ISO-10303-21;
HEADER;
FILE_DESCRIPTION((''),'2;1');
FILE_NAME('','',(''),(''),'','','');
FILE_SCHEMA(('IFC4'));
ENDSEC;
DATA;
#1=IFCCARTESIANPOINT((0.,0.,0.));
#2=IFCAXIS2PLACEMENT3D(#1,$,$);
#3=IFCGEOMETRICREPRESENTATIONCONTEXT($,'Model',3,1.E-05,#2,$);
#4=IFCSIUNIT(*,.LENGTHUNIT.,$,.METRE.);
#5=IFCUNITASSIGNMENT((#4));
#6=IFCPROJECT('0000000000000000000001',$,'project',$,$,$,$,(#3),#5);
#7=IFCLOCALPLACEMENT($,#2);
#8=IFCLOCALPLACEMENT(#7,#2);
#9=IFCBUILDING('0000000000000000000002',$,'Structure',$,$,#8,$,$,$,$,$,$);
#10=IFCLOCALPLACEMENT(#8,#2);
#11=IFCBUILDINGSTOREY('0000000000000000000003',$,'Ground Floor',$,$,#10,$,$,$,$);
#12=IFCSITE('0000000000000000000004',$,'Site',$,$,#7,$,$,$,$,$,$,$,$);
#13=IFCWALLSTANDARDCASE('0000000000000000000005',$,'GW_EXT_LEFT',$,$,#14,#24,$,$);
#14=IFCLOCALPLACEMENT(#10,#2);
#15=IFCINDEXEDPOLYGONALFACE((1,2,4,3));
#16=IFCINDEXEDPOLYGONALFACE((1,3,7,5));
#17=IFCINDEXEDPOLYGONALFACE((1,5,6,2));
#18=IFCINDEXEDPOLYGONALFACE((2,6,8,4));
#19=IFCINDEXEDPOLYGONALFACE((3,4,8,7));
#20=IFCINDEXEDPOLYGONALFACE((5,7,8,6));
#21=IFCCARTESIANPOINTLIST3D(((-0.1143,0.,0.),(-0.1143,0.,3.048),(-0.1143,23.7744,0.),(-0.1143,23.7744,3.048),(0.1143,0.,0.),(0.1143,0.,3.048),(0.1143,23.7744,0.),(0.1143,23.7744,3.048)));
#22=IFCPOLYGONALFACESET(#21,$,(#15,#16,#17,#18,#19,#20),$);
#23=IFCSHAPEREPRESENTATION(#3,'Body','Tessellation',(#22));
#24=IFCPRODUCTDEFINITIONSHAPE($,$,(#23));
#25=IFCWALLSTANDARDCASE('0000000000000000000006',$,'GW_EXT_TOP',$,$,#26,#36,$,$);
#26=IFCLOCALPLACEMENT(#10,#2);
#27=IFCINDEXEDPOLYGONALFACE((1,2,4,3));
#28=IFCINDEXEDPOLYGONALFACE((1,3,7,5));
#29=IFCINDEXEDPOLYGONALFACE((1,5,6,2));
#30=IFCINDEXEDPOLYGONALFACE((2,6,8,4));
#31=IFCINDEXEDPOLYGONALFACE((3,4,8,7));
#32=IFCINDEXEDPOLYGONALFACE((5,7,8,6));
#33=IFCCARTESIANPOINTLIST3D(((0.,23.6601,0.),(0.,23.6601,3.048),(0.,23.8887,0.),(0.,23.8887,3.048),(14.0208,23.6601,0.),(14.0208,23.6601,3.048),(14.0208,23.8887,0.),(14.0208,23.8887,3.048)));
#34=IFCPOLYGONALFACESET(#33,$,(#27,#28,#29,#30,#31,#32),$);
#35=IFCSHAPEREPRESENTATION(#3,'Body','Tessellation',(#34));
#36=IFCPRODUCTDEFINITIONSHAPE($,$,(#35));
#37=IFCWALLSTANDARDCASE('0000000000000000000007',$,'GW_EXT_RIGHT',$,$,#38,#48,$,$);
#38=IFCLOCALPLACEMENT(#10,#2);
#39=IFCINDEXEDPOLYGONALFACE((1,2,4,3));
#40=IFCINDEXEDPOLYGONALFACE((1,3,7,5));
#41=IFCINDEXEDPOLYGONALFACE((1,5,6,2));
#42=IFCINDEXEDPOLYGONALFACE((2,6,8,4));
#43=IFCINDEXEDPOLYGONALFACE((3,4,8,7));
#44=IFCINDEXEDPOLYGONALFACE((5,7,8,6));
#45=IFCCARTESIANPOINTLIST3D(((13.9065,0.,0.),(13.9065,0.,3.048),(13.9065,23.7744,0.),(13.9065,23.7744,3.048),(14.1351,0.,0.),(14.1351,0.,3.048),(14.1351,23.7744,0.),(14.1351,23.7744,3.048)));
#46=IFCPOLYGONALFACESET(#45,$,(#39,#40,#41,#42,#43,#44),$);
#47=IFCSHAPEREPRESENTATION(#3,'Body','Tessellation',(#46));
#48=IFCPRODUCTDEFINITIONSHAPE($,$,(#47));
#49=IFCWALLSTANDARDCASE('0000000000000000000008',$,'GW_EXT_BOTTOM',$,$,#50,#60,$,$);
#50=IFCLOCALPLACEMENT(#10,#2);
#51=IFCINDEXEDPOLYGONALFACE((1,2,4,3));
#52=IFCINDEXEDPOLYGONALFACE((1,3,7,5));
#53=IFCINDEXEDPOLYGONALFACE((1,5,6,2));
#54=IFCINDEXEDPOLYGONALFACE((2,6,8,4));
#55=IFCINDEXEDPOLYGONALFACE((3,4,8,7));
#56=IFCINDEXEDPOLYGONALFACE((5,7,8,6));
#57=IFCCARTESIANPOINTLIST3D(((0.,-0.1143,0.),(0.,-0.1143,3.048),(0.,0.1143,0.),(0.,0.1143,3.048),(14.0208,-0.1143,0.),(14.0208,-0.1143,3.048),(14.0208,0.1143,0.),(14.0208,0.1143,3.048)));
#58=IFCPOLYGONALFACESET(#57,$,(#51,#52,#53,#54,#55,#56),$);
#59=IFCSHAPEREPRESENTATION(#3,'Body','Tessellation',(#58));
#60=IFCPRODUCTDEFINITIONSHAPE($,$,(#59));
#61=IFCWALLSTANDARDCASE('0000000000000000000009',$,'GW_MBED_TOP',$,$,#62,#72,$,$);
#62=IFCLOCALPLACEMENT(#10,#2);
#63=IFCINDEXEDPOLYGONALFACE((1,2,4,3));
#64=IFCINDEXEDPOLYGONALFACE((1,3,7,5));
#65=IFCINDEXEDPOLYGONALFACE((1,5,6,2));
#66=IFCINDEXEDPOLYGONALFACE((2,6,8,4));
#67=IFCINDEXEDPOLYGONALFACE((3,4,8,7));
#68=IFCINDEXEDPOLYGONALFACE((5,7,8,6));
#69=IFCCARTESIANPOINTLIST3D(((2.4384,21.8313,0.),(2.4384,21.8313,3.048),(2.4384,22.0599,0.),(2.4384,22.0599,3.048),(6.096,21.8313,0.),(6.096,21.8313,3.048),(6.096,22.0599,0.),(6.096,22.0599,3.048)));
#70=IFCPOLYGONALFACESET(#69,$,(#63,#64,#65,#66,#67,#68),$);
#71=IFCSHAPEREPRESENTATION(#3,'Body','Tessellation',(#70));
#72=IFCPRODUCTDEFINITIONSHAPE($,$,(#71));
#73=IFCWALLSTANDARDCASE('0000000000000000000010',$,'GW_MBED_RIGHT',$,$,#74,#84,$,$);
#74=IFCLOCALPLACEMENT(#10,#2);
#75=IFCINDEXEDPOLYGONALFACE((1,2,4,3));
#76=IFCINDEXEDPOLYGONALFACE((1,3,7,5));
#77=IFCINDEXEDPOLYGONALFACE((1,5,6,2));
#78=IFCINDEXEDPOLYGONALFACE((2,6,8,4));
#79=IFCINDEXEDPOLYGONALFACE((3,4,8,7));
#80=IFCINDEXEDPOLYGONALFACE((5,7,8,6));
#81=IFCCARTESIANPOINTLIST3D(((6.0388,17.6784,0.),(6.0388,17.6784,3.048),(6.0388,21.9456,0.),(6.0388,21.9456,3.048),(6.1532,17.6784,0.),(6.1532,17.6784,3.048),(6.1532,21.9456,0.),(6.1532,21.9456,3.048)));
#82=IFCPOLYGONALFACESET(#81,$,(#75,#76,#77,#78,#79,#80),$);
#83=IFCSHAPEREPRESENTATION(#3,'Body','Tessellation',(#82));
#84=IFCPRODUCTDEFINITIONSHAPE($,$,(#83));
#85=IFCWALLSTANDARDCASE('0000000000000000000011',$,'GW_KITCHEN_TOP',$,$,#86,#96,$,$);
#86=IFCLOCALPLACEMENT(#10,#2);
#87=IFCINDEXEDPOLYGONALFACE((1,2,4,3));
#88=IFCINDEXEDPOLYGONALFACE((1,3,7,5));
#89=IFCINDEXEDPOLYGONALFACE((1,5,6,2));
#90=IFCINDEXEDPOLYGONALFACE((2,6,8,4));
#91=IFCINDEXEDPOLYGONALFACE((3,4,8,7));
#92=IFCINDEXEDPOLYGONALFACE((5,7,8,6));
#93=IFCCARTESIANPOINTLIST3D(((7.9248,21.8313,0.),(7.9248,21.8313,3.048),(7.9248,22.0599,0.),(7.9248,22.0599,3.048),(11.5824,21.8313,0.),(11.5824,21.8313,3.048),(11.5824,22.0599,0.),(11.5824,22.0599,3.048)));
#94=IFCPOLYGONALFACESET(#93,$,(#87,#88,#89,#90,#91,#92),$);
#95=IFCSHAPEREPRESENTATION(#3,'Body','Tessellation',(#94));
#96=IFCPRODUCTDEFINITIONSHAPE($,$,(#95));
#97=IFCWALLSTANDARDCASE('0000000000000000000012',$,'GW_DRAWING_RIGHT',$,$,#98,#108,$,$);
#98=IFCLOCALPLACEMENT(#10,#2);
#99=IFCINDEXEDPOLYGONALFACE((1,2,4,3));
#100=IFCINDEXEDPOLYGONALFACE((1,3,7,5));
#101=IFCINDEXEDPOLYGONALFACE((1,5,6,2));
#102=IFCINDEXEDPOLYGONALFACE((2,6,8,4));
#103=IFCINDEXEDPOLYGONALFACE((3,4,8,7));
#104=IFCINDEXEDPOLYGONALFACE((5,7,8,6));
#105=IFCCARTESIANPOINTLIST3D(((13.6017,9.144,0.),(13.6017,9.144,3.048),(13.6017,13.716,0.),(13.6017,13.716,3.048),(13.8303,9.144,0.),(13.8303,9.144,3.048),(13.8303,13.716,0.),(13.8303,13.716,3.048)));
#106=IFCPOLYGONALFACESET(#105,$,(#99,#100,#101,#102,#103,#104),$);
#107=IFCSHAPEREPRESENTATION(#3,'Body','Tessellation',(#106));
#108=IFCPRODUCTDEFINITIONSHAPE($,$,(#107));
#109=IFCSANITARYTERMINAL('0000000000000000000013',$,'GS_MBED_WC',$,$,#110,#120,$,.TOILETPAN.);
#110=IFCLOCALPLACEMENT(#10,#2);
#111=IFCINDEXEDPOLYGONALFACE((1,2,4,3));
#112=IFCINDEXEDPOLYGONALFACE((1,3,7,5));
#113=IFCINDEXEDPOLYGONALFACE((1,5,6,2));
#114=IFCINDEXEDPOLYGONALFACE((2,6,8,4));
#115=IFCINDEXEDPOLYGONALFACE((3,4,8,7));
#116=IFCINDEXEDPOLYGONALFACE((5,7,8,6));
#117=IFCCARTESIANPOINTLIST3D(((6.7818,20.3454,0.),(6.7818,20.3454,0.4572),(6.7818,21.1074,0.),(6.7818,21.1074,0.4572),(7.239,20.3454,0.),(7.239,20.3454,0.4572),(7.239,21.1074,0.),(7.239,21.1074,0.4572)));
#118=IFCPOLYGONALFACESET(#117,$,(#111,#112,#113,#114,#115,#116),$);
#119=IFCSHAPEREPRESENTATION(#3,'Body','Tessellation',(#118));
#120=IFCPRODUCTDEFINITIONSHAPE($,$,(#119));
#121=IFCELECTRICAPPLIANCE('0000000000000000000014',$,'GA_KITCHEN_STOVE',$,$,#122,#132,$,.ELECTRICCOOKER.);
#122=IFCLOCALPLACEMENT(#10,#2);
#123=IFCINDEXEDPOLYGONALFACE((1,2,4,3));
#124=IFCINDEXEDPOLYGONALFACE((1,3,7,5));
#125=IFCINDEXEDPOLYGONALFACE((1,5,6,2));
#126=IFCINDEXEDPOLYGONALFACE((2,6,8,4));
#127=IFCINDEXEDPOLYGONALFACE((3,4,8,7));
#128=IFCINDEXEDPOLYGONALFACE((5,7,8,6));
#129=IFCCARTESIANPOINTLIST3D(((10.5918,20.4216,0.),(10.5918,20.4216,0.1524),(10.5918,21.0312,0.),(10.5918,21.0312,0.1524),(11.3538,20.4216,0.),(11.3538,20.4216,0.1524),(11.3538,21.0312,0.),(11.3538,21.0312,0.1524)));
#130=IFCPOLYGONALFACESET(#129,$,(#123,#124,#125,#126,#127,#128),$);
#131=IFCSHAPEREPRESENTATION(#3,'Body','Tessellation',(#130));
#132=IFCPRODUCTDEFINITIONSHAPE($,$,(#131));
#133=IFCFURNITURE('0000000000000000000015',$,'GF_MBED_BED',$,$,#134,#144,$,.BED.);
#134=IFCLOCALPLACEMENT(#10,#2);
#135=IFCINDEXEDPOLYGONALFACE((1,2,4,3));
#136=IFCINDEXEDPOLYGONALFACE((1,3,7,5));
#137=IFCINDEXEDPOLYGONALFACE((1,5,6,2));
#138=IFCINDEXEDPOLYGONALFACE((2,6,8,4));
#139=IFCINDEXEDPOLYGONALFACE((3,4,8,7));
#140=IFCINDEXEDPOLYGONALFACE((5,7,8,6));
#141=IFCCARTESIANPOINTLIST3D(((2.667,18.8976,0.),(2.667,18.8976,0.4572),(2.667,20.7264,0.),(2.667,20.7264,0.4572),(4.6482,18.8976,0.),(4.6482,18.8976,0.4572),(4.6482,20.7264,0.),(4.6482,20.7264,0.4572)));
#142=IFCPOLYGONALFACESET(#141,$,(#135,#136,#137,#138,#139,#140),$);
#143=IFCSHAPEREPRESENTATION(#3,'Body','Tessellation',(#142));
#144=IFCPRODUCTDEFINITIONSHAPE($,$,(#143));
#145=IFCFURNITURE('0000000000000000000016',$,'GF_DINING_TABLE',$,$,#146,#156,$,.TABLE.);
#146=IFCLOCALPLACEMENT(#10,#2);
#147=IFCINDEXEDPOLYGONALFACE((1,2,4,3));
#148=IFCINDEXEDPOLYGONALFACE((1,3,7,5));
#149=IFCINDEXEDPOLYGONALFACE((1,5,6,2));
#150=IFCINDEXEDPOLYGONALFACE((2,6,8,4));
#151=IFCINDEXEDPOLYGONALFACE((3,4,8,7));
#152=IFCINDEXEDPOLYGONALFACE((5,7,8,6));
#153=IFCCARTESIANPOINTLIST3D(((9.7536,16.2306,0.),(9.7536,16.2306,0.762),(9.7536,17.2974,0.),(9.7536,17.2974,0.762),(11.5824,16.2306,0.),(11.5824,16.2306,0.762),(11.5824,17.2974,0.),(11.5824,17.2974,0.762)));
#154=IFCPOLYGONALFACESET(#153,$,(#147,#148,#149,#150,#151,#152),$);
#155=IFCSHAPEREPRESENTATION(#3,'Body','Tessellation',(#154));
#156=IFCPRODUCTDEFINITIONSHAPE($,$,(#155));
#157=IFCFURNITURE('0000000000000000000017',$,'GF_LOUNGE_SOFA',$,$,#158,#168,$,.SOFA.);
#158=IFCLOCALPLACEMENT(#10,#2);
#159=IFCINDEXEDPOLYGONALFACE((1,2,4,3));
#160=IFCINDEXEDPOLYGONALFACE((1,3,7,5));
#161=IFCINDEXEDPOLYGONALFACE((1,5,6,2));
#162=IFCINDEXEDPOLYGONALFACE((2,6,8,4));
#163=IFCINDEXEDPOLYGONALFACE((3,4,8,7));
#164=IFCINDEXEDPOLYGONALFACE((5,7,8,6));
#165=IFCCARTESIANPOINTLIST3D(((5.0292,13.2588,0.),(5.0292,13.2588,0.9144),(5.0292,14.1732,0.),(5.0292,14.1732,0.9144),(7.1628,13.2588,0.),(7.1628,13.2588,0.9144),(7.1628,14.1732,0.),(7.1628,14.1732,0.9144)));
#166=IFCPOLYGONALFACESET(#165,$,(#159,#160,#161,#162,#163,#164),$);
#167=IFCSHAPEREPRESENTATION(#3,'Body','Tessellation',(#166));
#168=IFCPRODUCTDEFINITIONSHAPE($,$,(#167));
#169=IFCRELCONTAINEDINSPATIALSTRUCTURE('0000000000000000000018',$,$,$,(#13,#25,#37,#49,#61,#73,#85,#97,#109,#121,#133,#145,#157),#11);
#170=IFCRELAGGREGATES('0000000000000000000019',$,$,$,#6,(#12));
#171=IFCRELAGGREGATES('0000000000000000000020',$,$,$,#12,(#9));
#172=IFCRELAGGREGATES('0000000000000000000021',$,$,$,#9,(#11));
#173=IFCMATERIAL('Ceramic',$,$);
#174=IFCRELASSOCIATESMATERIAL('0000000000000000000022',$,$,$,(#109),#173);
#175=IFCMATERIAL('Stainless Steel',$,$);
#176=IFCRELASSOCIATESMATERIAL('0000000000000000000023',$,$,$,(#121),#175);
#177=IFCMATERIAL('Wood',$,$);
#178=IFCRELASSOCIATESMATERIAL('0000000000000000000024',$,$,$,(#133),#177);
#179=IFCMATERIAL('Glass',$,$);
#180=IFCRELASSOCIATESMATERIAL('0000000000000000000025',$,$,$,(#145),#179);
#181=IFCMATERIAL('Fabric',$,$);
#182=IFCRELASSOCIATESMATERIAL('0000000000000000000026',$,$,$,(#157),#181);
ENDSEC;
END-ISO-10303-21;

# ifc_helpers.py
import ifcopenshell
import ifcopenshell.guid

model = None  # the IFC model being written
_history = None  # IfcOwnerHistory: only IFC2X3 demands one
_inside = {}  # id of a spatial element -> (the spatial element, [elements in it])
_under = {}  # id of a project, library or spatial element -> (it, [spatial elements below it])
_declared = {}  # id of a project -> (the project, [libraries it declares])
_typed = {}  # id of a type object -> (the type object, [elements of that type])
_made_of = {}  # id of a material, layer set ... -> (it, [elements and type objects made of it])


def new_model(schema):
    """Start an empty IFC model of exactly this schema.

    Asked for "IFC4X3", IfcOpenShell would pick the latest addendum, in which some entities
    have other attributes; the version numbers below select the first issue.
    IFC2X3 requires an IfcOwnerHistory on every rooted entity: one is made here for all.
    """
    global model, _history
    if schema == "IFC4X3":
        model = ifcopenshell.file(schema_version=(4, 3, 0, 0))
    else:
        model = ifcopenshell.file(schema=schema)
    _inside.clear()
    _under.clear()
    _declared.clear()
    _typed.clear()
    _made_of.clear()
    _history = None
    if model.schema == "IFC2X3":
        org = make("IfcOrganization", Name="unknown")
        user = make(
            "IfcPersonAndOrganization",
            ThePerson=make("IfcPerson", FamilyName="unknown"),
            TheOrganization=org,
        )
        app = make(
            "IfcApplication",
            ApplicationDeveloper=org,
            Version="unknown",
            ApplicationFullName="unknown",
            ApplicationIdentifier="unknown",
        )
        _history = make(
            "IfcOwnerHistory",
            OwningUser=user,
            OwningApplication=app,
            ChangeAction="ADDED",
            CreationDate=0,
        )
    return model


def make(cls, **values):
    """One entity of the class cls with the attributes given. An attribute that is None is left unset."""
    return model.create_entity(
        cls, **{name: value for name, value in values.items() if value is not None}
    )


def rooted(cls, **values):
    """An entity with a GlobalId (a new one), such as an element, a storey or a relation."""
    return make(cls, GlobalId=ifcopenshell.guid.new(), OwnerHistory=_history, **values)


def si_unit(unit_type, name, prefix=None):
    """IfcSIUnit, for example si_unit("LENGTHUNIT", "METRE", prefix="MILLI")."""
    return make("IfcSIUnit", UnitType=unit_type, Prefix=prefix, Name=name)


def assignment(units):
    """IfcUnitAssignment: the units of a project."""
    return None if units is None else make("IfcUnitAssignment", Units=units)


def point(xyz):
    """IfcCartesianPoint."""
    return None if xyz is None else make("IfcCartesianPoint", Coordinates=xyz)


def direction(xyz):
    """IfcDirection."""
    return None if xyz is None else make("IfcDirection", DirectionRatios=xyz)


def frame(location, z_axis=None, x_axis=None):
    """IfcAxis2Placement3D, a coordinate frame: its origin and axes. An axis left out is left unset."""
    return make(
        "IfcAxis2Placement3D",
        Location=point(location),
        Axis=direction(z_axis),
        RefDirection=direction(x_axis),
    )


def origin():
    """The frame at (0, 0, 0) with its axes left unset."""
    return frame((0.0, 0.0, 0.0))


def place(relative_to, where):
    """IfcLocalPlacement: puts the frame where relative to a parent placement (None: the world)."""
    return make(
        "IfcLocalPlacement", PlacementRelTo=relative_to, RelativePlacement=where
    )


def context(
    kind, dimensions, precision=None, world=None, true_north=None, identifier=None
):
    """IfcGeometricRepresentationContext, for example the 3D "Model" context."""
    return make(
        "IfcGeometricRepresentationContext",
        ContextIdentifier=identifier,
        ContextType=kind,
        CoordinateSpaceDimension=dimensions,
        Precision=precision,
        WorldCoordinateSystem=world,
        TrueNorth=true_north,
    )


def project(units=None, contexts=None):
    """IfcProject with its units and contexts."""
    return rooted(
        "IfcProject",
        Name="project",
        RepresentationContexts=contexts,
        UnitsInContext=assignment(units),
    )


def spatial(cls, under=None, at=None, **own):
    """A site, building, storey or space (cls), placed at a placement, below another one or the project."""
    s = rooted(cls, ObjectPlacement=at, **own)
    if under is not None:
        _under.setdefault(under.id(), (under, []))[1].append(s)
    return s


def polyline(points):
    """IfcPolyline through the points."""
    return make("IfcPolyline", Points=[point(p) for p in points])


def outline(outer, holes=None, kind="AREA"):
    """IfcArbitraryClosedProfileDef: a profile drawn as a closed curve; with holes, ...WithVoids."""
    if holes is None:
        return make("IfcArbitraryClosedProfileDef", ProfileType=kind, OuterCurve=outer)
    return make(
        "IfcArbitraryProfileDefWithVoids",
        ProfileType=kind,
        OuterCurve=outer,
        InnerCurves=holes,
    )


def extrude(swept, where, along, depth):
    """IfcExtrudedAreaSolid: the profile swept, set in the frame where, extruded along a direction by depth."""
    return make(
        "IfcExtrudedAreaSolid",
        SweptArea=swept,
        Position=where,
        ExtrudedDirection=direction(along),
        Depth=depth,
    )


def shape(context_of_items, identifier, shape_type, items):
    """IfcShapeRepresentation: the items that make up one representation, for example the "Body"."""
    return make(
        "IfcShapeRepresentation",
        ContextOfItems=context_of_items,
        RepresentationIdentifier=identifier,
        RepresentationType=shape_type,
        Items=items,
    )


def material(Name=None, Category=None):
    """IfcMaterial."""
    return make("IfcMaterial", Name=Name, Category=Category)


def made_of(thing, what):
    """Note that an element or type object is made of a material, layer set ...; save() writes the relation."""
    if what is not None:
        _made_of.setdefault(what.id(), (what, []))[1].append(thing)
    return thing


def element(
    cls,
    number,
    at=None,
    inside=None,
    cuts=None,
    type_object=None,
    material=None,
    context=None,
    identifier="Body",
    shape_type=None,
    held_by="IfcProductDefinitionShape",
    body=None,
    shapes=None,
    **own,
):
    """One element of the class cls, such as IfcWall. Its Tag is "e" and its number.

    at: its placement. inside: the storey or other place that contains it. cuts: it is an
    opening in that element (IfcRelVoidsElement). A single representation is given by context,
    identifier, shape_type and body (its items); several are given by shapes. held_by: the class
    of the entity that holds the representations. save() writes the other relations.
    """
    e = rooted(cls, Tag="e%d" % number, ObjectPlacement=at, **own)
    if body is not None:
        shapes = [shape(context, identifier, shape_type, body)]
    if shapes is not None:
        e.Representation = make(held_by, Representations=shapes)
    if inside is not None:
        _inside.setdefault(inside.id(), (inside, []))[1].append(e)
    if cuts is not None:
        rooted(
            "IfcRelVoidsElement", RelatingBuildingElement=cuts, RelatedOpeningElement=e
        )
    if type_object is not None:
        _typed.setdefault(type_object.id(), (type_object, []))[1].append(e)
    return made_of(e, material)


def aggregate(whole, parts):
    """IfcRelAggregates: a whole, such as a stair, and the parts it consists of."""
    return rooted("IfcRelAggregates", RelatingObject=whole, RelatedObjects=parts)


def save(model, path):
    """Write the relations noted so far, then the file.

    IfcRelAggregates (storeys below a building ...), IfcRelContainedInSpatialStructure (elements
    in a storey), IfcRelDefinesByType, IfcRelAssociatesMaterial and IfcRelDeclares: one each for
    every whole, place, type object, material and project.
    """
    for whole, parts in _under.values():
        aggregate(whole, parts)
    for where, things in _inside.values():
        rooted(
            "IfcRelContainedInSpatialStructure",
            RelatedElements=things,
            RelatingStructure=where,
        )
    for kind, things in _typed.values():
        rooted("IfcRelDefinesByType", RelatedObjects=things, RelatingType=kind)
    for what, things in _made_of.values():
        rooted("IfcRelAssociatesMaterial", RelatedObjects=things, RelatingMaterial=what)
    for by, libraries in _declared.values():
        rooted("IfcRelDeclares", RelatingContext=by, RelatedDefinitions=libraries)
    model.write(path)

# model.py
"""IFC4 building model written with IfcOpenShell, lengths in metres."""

from ifc_helpers import new_model, si_unit, frame, origin, place, context, project, spatial, polyline, outline, extrude, material, element, save


model = new_model("IFC4")

# Units and contexts
model_context = context("Model", 3, precision=1e-05, world=origin())
ifc_project = project(units=[si_unit("LENGTHUNIT", "METRE")], contexts=[model_context])

# Site, building, storey
site_placement = place(None, origin())
site = spatial("IfcSite", under=ifc_project, at=site_placement, Name="Site")
building_placement = place(site_placement, origin())
building = spatial("IfcBuilding", under=site, at=building_placement, Name="Structure")
storey_placement = place(building_placement, origin())
storey = spatial("IfcBuildingStorey", under=building, at=storey_placement, Name="Ground Floor")

# Walls
wall_1_placement = place(storey_placement, frame((0.0, 0.0, 0.0), x_axis=(0.0, 1.0, 0.0)))
element("IfcWallStandardCase", 1, at=wall_1_placement, inside=storey, Name="GW_EXT_LEFT", context=model_context, shape_type="SweptSolid", body=[
    extrude(outline(polyline([(0.0, -0.1143), (23.7744, -0.1143), (23.7744, 0.1143), (0.0, 0.1143), (0.0, -0.1143)])), origin(), (0.0, 0.0, 1.0), 3.048),
])
wall_2_placement = place(storey_placement, frame((0.0, 23.7744, 0.0), x_axis=(1.0, 0.0, 0.0)))
element("IfcWallStandardCase", 2, at=wall_2_placement, inside=storey, Name="GW_EXT_TOP", context=model_context, shape_type="SweptSolid", body=[
    extrude(outline(polyline([(0.0, -0.1143), (14.0208, -0.1143), (14.0208, 0.1143), (0.0, 0.1143), (0.0, -0.1143)])), origin(), (0.0, 0.0, 1.0), 3.048),
])
wall_3_placement = place(storey_placement, frame((14.0208, 23.7744, 0.0), x_axis=(0.0, -1.0, 0.0)))
element("IfcWallStandardCase", 3, at=wall_3_placement, inside=storey, Name="GW_EXT_RIGHT", context=model_context, shape_type="SweptSolid", body=[
    extrude(outline(polyline([(0.0, -0.1143), (23.7744, -0.1143), (23.7744, 0.1143), (0.0, 0.1143), (0.0, -0.1143)])), origin(), (0.0, 0.0, 1.0), 3.048),
])
wall_4_placement = place(storey_placement, frame((14.0208, 0.0, 0.0), x_axis=(-1.0, 0.0, 0.0)))
element("IfcWallStandardCase", 4, at=wall_4_placement, inside=storey, Name="GW_EXT_BOTTOM", context=model_context, shape_type="SweptSolid", body=[
    extrude(outline(polyline([(0.0, -0.1143), (14.0208, -0.1143), (14.0208, 0.1143), (0.0, 0.1143), (0.0, -0.1143)])), origin(), (0.0, 0.0, 1.0), 3.048),
])
wall_5_placement = place(storey_placement, frame((2.4384, 21.9456, 0.0), x_axis=(1.0, 0.0, 0.0)))
element("IfcWallStandardCase", 5, at=wall_5_placement, inside=storey, Name="GW_MBED_TOP", context=model_context, shape_type="SweptSolid", body=[
    extrude(outline(polyline([(0.0, -0.1143), (3.6576, -0.1143), (3.6576, 0.1143), (0.0, 0.1143), (0.0, -0.1143)])), origin(), (0.0, 0.0, 1.0), 3.048),
])
wall_6_placement = place(storey_placement, frame((6.096, 21.9456, 0.0), x_axis=(0.0, -1.0, 0.0)))
element("IfcWallStandardCase", 6, at=wall_6_placement, inside=storey, Name="GW_MBED_RIGHT", context=model_context, shape_type="SweptSolid", body=[
    extrude(outline(polyline([(0.0, -0.0572), (4.2672, -0.0572), (4.2672, 0.0572), (0.0, 0.0572), (0.0, -0.0572)])), origin(), (0.0, 0.0, 1.0), 3.048),
])
wall_7_placement = place(storey_placement, frame((7.9248, 21.9456, 0.0), x_axis=(1.0, 0.0, 0.0)))
element("IfcWallStandardCase", 7, at=wall_7_placement, inside=storey, Name="GW_KITCHEN_TOP", context=model_context, shape_type="SweptSolid", body=[
    extrude(outline(polyline([(0.0, -0.1143), (3.6576, -0.1143), (3.6576, 0.1143), (0.0, 0.1143), (0.0, -0.1143)])), origin(), (0.0, 0.0, 1.0), 3.048),
])
wall_8_placement = place(storey_placement, frame((13.716, 9.144, 0.0), x_axis=(0.0, 1.0, 0.0)))
element("IfcWallStandardCase", 8, at=wall_8_placement, inside=storey, Name="GW_DRAWING_RIGHT", context=model_context, shape_type="SweptSolid", body=[
    extrude(outline(polyline([(0.0, -0.1143), (4.572, -0.1143), (4.572, 0.1143), (0.0, 0.1143), (0.0, -0.1143)])), origin(), (0.0, 0.0, 1.0), 3.048),
])

# Sanitary terminal
ifc_material_1 = material(Name="Ceramic")
sanitary_terminal_placement = place(storey_placement, frame((7.0104, 20.7264, 0.0)))
element("IfcSanitaryTerminal", 9, at=sanitary_terminal_placement, inside=storey, material=ifc_material_1, Name="GS_MBED_WC", PredefinedType="TOILETPAN", context=model_context, shape_type="SweptSolid", body=[
    extrude(outline(polyline([(-0.2286, -0.381), (0.2286, -0.381), (0.2286, 0.381), (-0.2286, 0.381), (-0.2286, -0.381)])), origin(), (0.0, 0.0, 1.0), 0.4572),
])

# Electric appliance
ifc_material_2 = material(Name="Stainless Steel")
electric_appliance_placement = place(storey_placement, frame((10.9728, 20.7264, 0.0)))
element("IfcElectricAppliance", 10, at=electric_appliance_placement, inside=storey, material=ifc_material_2, Name="GA_KITCHEN_STOVE", PredefinedType="ELECTRICCOOKER", context=model_context, shape_type="SweptSolid", body=[
    extrude(outline(polyline([(-0.381, -0.3048), (0.381, -0.3048), (0.381, 0.3048), (-0.381, 0.3048), (-0.381, -0.3048)])), origin(), (0.0, 0.0, 1.0), 0.1524),
])

# Furniture
ifc_material_3 = material(Name="Wood")
furniture_1_placement = place(storey_placement, frame((3.6576, 19.812, 0.0)))
element("IfcFurniture", 11, at=furniture_1_placement, inside=storey, material=ifc_material_3, Name="GF_MBED_BED", PredefinedType="BED", context=model_context, shape_type="SweptSolid", body=[
    extrude(outline(polyline([(-0.9906, -0.9144), (0.9906, -0.9144), (0.9906, 0.9144), (-0.9906, 0.9144), (-0.9906, -0.9144)])), origin(), (0.0, 0.0, 1.0), 0.4572),
])
ifc_material_4 = material(Name="Glass")
furniture_2_placement = place(storey_placement, frame((10.668, 16.764, 0.0)))
element("IfcFurniture", 12, at=furniture_2_placement, inside=storey, material=ifc_material_4, Name="GF_DINING_TABLE", PredefinedType="TABLE", context=model_context, shape_type="SweptSolid", body=[
    extrude(outline(polyline([(-0.9144, -0.5334), (0.9144, -0.5334), (0.9144, 0.5334), (-0.9144, 0.5334), (-0.9144, -0.5334)])), origin(), (0.0, 0.0, 1.0), 0.762),
])
ifc_material_5 = material(Name="Fabric")
furniture_3_placement = place(storey_placement, frame((6.096, 13.716, 0.0)))
element("IfcFurniture", 13, at=furniture_3_placement, inside=storey, material=ifc_material_5, Name="GF_LOUNGE_SOFA", PredefinedType="SOFA", context=model_context, shape_type="SweptSolid", body=[
    extrude(outline(polyline([(-1.0668, -0.4572), (1.0668, -0.4572), (1.0668, 0.4572), (-1.0668, 0.4572), (-1.0668, -0.4572)])), origin(), (0.0, 0.0, 1.0), 0.9144),
])

save(model, "model.ifc")
